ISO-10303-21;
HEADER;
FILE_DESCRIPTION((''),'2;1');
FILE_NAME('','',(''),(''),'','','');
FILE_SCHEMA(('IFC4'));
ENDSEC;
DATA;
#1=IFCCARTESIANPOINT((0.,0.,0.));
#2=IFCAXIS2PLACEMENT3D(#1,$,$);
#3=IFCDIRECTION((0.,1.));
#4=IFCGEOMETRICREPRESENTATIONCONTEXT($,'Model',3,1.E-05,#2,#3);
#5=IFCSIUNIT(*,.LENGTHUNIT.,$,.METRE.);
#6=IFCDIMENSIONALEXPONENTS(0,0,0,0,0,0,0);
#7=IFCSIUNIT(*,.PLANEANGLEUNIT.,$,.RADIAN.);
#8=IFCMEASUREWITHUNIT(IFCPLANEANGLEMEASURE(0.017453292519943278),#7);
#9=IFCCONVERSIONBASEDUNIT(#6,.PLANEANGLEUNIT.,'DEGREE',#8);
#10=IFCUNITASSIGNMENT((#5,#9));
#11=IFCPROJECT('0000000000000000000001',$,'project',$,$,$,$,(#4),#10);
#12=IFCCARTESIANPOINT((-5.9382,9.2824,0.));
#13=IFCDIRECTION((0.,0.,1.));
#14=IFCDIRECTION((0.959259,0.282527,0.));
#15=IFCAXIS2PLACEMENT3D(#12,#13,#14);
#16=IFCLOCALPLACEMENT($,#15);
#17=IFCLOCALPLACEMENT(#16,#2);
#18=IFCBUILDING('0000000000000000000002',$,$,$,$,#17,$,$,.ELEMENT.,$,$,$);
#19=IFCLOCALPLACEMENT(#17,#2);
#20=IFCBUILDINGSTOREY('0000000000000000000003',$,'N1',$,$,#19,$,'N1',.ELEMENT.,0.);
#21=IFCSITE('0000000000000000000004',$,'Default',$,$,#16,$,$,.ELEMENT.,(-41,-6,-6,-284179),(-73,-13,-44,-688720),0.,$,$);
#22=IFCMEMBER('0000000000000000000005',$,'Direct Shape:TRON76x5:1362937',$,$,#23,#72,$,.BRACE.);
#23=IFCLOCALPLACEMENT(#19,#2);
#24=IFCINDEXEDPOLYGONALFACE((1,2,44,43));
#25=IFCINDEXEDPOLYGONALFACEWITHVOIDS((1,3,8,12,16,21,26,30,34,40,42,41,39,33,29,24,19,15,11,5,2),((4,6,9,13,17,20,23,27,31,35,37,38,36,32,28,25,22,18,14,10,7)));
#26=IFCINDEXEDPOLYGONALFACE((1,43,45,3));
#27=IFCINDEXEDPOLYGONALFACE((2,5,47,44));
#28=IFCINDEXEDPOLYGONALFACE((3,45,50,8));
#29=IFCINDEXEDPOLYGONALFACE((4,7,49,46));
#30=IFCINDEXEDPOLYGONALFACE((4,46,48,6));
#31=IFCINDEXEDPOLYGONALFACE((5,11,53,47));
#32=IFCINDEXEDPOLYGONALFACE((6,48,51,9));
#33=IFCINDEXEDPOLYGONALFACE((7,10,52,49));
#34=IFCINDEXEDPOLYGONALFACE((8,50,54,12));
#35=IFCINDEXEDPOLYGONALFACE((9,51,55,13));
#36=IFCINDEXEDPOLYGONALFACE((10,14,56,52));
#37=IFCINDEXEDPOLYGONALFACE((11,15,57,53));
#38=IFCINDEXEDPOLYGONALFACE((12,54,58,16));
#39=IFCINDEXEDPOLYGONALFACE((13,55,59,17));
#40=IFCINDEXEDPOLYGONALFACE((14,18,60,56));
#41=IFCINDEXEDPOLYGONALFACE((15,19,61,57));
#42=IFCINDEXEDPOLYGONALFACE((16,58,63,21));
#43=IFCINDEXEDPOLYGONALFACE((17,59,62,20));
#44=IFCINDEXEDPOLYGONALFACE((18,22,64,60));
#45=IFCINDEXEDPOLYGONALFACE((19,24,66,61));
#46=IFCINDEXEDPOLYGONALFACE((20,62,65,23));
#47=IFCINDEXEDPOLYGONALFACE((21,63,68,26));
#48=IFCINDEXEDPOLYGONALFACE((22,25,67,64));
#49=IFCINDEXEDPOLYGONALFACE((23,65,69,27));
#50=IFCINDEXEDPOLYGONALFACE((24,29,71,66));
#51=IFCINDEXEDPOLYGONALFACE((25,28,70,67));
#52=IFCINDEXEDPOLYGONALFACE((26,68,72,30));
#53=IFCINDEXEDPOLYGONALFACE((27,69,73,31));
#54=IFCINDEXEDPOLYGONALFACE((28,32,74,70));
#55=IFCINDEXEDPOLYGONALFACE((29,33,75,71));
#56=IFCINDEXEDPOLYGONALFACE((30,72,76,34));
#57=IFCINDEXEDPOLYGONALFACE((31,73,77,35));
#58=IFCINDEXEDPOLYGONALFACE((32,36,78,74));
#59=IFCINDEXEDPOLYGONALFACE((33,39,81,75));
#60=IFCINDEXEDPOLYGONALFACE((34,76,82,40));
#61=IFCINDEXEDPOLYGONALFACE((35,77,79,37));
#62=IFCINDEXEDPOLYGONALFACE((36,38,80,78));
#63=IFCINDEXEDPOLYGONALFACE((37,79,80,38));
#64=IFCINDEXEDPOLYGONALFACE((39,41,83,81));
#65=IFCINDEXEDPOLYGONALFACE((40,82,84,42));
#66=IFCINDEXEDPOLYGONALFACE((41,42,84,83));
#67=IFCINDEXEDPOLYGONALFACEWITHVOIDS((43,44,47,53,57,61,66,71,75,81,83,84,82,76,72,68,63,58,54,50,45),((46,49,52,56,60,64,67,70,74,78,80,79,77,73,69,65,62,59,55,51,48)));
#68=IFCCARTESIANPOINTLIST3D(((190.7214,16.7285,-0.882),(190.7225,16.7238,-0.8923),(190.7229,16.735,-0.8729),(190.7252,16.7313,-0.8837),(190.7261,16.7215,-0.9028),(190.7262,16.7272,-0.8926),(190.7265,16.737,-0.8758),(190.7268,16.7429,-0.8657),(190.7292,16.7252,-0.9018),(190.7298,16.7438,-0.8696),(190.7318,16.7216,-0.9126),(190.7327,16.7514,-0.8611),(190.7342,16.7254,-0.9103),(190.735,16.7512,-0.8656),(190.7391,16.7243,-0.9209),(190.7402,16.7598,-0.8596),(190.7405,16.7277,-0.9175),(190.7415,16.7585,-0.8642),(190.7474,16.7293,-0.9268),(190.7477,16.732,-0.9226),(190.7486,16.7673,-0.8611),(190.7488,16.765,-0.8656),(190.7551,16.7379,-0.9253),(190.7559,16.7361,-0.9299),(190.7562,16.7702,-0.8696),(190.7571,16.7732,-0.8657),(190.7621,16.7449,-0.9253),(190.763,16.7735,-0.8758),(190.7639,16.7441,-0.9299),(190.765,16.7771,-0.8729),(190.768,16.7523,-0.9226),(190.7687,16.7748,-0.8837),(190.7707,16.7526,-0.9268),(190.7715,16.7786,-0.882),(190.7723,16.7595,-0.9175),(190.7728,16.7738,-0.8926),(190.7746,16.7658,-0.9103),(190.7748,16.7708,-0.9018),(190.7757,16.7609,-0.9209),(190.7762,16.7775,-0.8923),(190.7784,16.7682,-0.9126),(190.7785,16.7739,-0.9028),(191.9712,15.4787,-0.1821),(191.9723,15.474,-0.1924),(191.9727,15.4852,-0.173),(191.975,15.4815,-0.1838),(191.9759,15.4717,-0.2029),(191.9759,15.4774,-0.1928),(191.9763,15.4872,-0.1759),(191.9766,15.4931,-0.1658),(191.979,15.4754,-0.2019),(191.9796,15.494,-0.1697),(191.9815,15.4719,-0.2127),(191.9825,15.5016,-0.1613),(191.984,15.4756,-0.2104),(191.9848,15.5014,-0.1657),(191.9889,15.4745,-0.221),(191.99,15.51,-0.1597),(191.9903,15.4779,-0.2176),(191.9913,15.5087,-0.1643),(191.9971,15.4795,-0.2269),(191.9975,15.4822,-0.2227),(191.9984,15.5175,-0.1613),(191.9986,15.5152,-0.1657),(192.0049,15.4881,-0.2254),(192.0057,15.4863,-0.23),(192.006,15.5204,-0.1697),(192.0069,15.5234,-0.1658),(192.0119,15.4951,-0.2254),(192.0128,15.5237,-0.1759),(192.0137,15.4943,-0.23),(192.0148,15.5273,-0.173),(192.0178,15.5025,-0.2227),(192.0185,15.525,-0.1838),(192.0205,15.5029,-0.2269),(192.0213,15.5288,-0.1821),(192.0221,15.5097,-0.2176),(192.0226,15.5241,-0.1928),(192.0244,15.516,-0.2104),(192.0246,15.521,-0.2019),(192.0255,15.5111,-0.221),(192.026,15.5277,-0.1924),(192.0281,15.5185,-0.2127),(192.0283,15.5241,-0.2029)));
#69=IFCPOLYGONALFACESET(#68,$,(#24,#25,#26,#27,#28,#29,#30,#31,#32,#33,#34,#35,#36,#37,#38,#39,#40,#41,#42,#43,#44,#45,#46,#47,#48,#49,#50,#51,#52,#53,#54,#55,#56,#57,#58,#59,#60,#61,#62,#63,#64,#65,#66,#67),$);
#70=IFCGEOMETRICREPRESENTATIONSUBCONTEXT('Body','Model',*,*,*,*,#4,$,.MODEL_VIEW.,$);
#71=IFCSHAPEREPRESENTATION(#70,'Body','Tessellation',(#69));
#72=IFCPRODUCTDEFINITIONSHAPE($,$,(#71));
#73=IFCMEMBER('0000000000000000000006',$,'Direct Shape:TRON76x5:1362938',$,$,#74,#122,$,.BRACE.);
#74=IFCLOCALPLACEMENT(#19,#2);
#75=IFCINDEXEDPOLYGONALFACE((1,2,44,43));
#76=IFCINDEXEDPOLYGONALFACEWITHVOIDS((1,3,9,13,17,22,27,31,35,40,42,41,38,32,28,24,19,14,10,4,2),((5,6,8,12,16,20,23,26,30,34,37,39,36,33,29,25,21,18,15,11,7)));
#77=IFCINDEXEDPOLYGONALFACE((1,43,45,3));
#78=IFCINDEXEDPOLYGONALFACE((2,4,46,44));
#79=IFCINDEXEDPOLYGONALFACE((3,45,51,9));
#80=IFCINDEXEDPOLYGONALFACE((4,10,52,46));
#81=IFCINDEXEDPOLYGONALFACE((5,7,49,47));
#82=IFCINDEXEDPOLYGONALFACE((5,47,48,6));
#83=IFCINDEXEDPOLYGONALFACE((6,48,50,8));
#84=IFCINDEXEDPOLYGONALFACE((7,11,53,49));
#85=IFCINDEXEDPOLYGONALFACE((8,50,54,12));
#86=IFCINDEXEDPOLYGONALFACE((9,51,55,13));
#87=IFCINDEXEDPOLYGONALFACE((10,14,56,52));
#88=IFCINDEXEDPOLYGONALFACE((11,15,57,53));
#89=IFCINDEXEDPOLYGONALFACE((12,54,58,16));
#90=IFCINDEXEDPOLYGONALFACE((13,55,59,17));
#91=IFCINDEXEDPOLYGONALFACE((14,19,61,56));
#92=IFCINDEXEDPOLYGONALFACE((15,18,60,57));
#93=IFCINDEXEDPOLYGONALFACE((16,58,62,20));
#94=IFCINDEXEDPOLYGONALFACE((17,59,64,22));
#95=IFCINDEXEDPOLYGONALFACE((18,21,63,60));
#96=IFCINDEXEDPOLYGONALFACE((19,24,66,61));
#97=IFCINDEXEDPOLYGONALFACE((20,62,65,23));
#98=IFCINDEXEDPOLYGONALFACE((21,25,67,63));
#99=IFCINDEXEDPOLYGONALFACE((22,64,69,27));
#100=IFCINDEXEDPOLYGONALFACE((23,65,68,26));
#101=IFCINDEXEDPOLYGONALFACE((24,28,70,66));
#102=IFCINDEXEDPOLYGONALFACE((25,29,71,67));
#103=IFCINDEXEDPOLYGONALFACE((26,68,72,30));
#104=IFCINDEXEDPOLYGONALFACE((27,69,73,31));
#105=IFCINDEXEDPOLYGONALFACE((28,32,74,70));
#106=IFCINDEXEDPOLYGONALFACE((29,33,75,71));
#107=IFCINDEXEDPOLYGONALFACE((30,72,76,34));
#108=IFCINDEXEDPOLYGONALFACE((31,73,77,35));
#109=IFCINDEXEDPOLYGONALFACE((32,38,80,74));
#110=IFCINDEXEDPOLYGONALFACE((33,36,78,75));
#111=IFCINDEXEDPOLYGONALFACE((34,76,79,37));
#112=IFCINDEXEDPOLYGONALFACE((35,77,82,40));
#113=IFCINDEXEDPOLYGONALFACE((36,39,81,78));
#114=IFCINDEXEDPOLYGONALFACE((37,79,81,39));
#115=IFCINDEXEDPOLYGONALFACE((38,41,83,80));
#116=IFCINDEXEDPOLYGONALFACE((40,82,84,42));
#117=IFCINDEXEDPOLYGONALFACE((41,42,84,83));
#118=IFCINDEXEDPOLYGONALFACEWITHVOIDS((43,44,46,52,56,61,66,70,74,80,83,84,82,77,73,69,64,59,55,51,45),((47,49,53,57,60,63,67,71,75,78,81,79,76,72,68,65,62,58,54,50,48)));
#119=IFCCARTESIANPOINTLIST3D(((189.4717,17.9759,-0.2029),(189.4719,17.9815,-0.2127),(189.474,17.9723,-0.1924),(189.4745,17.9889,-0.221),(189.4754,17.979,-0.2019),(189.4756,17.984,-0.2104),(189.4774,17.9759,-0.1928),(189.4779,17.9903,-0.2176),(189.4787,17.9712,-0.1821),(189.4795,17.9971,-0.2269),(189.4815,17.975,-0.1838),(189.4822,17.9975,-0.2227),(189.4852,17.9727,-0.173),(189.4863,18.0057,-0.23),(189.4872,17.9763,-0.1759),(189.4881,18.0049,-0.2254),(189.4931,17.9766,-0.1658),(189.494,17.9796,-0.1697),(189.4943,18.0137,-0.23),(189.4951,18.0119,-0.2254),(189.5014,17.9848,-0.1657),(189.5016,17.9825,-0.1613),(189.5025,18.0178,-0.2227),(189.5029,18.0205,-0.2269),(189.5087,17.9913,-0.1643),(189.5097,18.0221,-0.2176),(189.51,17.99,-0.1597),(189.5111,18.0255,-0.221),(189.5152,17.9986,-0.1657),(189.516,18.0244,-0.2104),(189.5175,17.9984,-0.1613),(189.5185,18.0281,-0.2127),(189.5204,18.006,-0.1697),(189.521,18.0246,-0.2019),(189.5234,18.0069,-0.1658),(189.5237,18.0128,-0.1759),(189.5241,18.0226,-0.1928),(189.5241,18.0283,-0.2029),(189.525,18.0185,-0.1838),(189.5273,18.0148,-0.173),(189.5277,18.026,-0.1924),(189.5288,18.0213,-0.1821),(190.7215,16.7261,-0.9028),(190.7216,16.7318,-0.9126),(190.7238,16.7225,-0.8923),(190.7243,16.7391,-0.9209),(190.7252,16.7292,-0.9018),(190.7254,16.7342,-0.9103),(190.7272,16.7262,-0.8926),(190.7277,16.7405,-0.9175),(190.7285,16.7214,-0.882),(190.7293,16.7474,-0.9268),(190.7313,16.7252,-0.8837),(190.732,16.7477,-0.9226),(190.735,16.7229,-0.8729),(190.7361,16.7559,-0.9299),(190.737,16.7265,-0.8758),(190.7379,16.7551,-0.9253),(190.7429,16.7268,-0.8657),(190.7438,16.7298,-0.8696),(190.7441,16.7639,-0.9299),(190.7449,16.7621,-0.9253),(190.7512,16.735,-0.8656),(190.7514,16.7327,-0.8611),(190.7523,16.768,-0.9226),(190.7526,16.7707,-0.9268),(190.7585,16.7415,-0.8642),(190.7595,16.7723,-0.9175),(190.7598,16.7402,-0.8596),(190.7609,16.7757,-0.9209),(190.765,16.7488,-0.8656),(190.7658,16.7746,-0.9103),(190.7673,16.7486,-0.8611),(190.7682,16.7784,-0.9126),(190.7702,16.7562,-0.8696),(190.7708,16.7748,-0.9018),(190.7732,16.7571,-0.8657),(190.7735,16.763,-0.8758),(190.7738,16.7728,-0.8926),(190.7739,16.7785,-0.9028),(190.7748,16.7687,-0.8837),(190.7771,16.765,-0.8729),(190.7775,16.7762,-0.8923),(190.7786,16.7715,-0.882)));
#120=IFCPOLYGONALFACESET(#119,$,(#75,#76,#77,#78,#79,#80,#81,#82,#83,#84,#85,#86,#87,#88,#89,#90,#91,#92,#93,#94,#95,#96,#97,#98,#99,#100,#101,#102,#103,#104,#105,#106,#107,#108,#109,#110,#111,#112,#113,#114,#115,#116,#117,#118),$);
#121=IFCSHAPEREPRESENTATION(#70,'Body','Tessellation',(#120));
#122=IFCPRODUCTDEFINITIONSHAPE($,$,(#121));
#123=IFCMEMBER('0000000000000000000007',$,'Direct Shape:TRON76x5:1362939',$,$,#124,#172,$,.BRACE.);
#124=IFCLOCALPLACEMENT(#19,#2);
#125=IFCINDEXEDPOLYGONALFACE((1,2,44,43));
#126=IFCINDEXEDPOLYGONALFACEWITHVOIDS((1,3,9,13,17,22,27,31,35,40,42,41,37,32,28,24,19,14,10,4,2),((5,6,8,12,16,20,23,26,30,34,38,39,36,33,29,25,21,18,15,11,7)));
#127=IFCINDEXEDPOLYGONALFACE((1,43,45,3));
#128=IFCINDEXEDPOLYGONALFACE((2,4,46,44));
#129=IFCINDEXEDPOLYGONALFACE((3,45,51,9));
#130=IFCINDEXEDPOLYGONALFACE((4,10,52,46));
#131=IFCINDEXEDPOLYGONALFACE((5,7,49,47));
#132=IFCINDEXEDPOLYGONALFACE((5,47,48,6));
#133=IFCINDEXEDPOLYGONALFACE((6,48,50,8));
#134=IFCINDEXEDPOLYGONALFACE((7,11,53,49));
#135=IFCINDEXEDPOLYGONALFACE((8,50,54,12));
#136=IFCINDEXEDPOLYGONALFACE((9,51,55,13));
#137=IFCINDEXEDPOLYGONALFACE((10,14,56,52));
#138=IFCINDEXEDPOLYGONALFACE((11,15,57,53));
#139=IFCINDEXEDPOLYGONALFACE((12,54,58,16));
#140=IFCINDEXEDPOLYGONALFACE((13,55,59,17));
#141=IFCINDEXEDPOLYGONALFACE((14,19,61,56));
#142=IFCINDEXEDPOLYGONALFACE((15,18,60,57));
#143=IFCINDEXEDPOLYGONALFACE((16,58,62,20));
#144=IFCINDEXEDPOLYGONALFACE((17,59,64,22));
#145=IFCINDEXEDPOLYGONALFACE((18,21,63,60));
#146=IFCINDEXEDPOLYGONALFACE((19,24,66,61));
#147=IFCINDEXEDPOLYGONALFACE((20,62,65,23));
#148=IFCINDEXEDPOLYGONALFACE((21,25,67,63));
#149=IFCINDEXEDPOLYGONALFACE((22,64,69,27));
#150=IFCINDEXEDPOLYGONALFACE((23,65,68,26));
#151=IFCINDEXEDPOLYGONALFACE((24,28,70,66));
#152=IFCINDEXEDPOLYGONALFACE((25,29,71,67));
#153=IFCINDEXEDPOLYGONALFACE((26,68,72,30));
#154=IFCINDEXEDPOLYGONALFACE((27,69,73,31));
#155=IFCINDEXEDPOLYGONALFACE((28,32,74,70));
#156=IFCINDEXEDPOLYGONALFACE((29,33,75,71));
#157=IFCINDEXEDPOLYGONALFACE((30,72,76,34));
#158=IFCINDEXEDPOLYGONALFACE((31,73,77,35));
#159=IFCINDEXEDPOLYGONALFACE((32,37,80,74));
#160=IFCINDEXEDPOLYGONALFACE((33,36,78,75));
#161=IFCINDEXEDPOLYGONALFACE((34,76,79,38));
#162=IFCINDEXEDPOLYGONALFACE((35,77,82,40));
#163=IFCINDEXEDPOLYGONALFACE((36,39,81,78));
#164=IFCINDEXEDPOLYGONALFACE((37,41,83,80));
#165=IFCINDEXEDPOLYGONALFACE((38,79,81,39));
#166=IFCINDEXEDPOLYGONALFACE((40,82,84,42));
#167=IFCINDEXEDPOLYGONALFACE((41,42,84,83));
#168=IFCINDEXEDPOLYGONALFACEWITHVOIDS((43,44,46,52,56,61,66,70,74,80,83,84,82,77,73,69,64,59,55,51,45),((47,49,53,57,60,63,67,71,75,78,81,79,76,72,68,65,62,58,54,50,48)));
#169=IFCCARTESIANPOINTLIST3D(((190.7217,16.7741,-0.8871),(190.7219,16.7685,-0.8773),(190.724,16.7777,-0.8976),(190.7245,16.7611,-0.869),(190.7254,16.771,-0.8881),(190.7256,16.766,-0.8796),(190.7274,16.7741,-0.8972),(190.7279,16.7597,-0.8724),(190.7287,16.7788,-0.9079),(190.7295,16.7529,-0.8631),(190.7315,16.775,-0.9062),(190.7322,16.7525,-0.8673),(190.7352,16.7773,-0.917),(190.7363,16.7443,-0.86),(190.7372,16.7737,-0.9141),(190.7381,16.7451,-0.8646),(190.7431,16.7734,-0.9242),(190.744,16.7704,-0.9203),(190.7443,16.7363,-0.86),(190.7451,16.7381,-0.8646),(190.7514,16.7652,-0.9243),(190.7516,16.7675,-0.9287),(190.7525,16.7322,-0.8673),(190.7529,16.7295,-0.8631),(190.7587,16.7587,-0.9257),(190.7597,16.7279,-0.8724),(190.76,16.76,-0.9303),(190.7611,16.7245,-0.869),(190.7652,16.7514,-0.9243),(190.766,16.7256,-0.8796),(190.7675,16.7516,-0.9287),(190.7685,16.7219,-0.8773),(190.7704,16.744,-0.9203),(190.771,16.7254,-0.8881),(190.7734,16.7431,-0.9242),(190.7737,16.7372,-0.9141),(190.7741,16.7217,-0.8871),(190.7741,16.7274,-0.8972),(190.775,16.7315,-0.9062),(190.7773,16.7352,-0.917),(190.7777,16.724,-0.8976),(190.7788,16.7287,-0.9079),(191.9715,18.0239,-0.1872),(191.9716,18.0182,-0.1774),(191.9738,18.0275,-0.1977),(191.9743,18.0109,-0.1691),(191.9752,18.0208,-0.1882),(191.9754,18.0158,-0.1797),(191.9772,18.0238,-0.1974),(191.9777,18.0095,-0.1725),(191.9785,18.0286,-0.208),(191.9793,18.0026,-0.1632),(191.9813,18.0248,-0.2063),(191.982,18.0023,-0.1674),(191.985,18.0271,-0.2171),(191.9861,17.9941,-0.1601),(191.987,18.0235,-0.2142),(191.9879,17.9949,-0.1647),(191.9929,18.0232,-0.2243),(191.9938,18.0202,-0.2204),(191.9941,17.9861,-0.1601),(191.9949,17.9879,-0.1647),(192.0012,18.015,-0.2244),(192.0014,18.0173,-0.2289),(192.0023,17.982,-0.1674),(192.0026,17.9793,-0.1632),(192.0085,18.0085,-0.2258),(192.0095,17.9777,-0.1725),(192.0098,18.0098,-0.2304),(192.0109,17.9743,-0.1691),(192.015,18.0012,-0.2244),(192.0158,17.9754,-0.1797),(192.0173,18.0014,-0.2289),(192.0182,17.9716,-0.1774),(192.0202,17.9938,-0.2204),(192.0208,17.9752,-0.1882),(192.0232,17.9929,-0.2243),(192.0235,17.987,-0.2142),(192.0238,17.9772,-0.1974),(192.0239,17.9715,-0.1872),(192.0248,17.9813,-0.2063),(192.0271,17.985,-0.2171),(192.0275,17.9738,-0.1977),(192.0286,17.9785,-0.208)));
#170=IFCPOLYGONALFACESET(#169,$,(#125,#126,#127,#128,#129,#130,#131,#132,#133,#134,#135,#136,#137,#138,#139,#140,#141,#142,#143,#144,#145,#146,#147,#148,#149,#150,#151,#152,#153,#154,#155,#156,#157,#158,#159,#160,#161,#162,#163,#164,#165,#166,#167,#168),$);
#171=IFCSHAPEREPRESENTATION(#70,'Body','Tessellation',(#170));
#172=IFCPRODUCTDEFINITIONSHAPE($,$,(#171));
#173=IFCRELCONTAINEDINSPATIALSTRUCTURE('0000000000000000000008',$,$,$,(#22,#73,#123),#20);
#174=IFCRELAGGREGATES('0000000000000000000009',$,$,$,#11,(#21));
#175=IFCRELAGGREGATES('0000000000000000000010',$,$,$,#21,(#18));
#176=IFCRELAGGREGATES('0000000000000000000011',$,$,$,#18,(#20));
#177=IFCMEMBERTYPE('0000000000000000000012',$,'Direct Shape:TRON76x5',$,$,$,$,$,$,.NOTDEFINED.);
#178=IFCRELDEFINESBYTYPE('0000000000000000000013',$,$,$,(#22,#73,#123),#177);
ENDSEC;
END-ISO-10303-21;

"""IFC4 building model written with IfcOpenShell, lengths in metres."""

from ifc_helpers import new_model, entity, si_unit, converted_unit, direction, frame, frame_2d, origin, origin_2d_with_axis, place, context, subcontext, project, spatial, hollow_circle, extrude, type_object, element, save


model = new_model("IFC4")

# Units and contexts
model_context = context("Model", 3, precision=1e-05, world=origin(), true_north=direction((0.0, 1.0)))
body_context = subcontext(model_context, "Body", "Model", "MODEL_VIEW")
ifc_project = project(units=[si_unit("LENGTHUNIT", "METRE"), converted_unit("PLANEANGLEUNIT", "DEGREE", entity("IfcPlaneAngleMeasure", 0.017453292519943278), si_unit("PLANEANGLEUNIT", "RADIAN"), dimensions=[0, 0, 0, 0, 0, 0, 0])], contexts=[model_context])

# Site, building, storey
site_placement = place(None, frame((-5.9382, 9.2824, 0.0), z_axis=(0.0, 0.0, 1.0), x_axis=(0.959259, 0.282527, 0.0)))
site = spatial("IfcSite", under=ifc_project, at=site_placement, Name="Default", CompositionType="ELEMENT", RefLatitude=(-41, -6, -6, -284179), RefLongitude=(-73, -13, -44, -688720), RefElevation=0.0)
building_placement = place(site_placement, origin())
building = spatial("IfcBuilding", under=site, at=building_placement, CompositionType="ELEMENT")
storey_placement = place(building_placement, origin())
storey = spatial("IfcBuildingStorey", under=building, at=storey_placement, Name="N1", LongName="N1", CompositionType="ELEMENT", Elevation=0.0)

# Members
member_type_1 = type_object("IfcMemberType", Name="Direct Shape:TRON76x5", PredefinedType="NOTDEFINED")
member_1_placement = place(storey_placement, origin())
element("IfcMember", 1, at=member_1_placement, inside=storey, type_object=member_type_1, Name="Direct Shape:TRON76x5:1362937", PredefinedType="BRACE", context=body_context, shape_type="SweptSolid", body=[
    extrude(hollow_circle(Radius=0.0381, WallThickness=0.005, at=frame_2d((0.0, 0.0), x_axis=(1.0, 0.0))), frame((191.9999, 15.5001, -0.1951), z_axis=(-0.65744, 0.65744, -0.368166), x_axis=(-0.260333, 0.260333, 0.92976)), (0.0, 0.0, 1.0), 1.901),
])
member_2_placement = place(storey_placement, origin())
element("IfcMember", 2, at=member_2_placement, inside=storey, type_object=member_type_1, Name="Direct Shape:TRON76x5:1362938", PredefinedType="BRACE", context=body_context, shape_type="SweptSolid", body=[
    extrude(hollow_circle(Radius=0.0381, WallThickness=0.005, at=frame_2d((0.0, 0.0), x_axis=(1.0, 0.0))), frame((189.5001, 17.9999, -0.1951), z_axis=(0.65744, -0.65744, -0.368166), x_axis=(0.260333, -0.260333, 0.92976)), (0.0, 0.0, 1.0), 1.901),
])
member_3_placement = place(storey_placement, origin())
element("IfcMember", 3, at=member_3_placement, inside=storey, type_object=member_type_1, Name="Direct Shape:TRON76x5:1362939", PredefinedType="BRACE", context=body_context, shape_type="SweptSolid", body=[
    extrude(hollow_circle(Radius=0.0381, WallThickness=0.005, at=origin_2d_with_axis()), frame((190.7501, 16.7501, -0.8949), z_axis=(0.65744, 0.65744, 0.368166), x_axis=(0.260333, 0.260333, -0.92976)), (0.0, 0.0, 1.0), 1.901),
])

save(model, "model.ifc")
